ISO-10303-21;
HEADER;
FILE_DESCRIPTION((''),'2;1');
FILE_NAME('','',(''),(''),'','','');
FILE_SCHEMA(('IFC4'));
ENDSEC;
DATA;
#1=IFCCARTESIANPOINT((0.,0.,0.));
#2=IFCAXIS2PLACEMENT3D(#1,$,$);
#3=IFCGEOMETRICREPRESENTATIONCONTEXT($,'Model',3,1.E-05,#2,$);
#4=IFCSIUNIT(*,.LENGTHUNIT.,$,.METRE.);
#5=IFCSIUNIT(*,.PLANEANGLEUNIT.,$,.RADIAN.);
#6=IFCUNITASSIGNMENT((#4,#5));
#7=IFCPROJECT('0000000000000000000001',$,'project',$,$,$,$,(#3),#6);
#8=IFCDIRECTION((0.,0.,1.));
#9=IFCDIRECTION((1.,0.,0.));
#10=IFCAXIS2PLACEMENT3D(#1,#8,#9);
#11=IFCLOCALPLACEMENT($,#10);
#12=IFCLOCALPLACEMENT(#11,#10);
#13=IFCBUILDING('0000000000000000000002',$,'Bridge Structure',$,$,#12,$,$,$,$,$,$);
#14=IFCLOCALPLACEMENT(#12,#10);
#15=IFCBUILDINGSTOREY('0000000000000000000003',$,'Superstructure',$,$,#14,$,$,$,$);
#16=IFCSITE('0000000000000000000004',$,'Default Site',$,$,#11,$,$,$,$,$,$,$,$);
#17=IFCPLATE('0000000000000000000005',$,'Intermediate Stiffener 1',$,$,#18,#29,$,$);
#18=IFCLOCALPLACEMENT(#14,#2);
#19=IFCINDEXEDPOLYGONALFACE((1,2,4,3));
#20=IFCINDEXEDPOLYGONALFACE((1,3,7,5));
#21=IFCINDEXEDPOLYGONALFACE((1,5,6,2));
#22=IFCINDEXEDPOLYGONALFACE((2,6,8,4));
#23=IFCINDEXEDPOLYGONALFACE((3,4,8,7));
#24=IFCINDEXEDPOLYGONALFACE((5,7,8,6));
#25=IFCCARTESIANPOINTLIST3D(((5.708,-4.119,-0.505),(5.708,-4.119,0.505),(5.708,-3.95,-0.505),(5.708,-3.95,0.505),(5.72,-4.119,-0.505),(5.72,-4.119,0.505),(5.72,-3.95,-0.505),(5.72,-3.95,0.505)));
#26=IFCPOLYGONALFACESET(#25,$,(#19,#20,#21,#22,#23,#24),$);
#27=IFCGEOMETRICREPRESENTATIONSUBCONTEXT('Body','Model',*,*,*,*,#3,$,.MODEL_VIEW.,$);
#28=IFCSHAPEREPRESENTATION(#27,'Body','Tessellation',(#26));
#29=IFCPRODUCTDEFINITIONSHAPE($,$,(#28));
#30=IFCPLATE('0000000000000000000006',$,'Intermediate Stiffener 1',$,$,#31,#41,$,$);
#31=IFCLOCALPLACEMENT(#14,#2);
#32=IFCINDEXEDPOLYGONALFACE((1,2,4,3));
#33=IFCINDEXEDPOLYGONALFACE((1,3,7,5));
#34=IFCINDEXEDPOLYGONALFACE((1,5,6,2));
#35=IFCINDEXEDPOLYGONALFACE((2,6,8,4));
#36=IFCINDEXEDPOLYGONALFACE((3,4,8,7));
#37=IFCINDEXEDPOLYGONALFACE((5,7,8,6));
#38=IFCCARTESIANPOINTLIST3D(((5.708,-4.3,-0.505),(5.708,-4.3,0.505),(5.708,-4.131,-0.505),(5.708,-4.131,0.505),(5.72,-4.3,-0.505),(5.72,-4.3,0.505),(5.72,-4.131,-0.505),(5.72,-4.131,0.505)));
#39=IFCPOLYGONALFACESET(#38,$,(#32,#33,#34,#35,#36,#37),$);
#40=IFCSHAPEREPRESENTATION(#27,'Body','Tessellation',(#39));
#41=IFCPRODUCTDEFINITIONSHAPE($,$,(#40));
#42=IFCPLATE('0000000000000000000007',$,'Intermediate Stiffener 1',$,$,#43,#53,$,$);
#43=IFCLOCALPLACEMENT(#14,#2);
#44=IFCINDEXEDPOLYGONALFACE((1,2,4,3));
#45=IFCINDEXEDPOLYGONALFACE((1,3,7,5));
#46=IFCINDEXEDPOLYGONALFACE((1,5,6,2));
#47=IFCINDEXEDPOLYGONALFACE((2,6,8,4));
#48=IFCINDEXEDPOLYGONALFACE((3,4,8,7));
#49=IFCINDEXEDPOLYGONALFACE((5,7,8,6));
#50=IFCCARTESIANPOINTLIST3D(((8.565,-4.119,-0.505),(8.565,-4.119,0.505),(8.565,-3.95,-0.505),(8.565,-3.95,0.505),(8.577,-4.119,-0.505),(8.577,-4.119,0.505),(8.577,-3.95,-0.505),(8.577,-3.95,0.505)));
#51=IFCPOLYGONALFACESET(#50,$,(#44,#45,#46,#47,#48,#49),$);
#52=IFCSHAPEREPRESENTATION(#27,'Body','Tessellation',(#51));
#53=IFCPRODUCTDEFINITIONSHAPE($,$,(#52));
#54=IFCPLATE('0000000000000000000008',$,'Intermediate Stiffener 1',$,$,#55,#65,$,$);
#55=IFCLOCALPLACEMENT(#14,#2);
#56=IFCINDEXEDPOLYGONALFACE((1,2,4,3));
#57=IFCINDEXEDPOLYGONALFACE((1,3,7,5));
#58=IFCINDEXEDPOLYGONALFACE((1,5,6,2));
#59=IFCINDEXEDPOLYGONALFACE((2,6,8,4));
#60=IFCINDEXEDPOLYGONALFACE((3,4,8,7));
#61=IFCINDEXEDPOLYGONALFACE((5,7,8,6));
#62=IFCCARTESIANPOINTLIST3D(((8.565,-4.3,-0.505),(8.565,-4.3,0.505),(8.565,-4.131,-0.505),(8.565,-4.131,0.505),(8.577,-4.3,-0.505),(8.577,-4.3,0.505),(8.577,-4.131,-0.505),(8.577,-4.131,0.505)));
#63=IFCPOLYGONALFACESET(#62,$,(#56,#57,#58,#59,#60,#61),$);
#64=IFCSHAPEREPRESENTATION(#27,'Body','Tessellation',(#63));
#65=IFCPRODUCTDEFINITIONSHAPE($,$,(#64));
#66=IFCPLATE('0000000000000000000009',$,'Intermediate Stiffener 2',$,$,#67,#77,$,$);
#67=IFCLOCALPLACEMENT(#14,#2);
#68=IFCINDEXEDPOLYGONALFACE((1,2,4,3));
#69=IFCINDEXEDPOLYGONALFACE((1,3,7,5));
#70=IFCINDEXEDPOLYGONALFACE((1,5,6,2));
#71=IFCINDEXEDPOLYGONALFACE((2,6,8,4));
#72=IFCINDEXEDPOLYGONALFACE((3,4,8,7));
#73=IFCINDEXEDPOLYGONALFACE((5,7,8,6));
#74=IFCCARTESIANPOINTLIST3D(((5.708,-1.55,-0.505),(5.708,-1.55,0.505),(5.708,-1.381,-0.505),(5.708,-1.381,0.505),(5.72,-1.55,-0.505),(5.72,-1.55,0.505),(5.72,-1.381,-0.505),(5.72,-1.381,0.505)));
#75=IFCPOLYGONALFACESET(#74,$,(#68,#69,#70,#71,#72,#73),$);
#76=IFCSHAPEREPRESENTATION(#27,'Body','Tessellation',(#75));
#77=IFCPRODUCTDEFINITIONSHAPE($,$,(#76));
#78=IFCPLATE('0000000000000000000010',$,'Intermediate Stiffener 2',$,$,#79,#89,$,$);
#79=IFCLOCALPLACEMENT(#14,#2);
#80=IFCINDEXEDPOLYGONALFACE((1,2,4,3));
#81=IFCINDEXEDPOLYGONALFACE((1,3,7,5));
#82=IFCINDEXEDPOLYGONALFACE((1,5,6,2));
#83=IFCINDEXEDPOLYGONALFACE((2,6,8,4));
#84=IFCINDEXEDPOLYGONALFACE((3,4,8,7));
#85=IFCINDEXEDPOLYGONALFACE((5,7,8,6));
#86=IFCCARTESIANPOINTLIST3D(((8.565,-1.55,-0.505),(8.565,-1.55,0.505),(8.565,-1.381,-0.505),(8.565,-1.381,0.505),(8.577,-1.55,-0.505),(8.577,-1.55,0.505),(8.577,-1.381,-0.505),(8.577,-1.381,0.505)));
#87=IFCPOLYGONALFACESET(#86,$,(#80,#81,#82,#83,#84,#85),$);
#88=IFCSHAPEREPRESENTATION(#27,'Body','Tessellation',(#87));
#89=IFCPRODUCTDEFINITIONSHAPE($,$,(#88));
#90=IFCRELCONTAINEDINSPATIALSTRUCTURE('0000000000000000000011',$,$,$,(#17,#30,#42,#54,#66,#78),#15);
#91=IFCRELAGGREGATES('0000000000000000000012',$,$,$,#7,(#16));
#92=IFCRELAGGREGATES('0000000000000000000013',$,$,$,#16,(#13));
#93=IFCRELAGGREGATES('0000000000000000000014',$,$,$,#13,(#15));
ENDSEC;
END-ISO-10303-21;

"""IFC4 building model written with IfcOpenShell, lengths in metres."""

from ifc_helpers import new_model, si_unit, frame, origin, origin_with_axes, origin_2d_with_axis, place, context, subcontext, project, spatial, rectangle, extrude, element, save


model = new_model("IFC4")

# Units and contexts
model_context = context("Model", 3, precision=1e-05, world=origin())
body_context = subcontext(model_context, "Body", "Model", "MODEL_VIEW")
ifc_project = project(units=[si_unit("LENGTHUNIT", "METRE"), si_unit("PLANEANGLEUNIT", "RADIAN")], contexts=[model_context])

# Site, building, storey
site_placement = place(None, origin_with_axes())
site = spatial("IfcSite", under=ifc_project, at=site_placement, Name="Default Site")
building_placement = place(site_placement, origin_with_axes())
building = spatial("IfcBuilding", under=site, at=building_placement, Name="Bridge Structure")
storey_placement = place(building_placement, origin_with_axes())
storey = spatial("IfcBuildingStorey", under=building, at=storey_placement, Name="Superstructure")

# Plates
for number, where, z_axis, x_axis, name in (
    (1, (5.714, -4.0345, -0.505), (0.0, 0.0, 1.0), (1.0, 0.0, 0.0), "Intermediate Stiffener 1"),
    (2, (5.714, -4.2155, -0.505), (0.0, 0.0, 1.0), (1.0, 0.0, 0.0), "Intermediate Stiffener 1"),
    (3, (8.571, -4.0345, -0.505), (0.0, 0.0, 1.0), (1.0, 0.0, 0.0), "Intermediate Stiffener 1"),
    (4, (8.571, -4.2155, -0.505), (0.0, 0.0, 1.0), (1.0, 0.0, 0.0), "Intermediate Stiffener 1"),
    (5, (5.714, -1.4655, -0.505), (0.0, 0.0, 1.0), (1.0, 0.0, 0.0), "Intermediate Stiffener 2"),
    (6, (8.571, -1.4655, -0.505), (0.0, 0.0, 1.0), (1.0, 0.0, 0.0), "Intermediate Stiffener 2"),
):
    element("IfcPlate", number, at=place(storey_placement, frame(where, z_axis=z_axis, x_axis=x_axis)), inside=storey, Name=name, context=body_context, shape_type="SweptSolid", body=[
        extrude(rectangle(XDim=0.012, YDim=0.169, at=origin_2d_with_axis()), origin_with_axes(), (0.0, 0.0, 1.0), 1.01),
    ])

save(model, "model.ifc")
